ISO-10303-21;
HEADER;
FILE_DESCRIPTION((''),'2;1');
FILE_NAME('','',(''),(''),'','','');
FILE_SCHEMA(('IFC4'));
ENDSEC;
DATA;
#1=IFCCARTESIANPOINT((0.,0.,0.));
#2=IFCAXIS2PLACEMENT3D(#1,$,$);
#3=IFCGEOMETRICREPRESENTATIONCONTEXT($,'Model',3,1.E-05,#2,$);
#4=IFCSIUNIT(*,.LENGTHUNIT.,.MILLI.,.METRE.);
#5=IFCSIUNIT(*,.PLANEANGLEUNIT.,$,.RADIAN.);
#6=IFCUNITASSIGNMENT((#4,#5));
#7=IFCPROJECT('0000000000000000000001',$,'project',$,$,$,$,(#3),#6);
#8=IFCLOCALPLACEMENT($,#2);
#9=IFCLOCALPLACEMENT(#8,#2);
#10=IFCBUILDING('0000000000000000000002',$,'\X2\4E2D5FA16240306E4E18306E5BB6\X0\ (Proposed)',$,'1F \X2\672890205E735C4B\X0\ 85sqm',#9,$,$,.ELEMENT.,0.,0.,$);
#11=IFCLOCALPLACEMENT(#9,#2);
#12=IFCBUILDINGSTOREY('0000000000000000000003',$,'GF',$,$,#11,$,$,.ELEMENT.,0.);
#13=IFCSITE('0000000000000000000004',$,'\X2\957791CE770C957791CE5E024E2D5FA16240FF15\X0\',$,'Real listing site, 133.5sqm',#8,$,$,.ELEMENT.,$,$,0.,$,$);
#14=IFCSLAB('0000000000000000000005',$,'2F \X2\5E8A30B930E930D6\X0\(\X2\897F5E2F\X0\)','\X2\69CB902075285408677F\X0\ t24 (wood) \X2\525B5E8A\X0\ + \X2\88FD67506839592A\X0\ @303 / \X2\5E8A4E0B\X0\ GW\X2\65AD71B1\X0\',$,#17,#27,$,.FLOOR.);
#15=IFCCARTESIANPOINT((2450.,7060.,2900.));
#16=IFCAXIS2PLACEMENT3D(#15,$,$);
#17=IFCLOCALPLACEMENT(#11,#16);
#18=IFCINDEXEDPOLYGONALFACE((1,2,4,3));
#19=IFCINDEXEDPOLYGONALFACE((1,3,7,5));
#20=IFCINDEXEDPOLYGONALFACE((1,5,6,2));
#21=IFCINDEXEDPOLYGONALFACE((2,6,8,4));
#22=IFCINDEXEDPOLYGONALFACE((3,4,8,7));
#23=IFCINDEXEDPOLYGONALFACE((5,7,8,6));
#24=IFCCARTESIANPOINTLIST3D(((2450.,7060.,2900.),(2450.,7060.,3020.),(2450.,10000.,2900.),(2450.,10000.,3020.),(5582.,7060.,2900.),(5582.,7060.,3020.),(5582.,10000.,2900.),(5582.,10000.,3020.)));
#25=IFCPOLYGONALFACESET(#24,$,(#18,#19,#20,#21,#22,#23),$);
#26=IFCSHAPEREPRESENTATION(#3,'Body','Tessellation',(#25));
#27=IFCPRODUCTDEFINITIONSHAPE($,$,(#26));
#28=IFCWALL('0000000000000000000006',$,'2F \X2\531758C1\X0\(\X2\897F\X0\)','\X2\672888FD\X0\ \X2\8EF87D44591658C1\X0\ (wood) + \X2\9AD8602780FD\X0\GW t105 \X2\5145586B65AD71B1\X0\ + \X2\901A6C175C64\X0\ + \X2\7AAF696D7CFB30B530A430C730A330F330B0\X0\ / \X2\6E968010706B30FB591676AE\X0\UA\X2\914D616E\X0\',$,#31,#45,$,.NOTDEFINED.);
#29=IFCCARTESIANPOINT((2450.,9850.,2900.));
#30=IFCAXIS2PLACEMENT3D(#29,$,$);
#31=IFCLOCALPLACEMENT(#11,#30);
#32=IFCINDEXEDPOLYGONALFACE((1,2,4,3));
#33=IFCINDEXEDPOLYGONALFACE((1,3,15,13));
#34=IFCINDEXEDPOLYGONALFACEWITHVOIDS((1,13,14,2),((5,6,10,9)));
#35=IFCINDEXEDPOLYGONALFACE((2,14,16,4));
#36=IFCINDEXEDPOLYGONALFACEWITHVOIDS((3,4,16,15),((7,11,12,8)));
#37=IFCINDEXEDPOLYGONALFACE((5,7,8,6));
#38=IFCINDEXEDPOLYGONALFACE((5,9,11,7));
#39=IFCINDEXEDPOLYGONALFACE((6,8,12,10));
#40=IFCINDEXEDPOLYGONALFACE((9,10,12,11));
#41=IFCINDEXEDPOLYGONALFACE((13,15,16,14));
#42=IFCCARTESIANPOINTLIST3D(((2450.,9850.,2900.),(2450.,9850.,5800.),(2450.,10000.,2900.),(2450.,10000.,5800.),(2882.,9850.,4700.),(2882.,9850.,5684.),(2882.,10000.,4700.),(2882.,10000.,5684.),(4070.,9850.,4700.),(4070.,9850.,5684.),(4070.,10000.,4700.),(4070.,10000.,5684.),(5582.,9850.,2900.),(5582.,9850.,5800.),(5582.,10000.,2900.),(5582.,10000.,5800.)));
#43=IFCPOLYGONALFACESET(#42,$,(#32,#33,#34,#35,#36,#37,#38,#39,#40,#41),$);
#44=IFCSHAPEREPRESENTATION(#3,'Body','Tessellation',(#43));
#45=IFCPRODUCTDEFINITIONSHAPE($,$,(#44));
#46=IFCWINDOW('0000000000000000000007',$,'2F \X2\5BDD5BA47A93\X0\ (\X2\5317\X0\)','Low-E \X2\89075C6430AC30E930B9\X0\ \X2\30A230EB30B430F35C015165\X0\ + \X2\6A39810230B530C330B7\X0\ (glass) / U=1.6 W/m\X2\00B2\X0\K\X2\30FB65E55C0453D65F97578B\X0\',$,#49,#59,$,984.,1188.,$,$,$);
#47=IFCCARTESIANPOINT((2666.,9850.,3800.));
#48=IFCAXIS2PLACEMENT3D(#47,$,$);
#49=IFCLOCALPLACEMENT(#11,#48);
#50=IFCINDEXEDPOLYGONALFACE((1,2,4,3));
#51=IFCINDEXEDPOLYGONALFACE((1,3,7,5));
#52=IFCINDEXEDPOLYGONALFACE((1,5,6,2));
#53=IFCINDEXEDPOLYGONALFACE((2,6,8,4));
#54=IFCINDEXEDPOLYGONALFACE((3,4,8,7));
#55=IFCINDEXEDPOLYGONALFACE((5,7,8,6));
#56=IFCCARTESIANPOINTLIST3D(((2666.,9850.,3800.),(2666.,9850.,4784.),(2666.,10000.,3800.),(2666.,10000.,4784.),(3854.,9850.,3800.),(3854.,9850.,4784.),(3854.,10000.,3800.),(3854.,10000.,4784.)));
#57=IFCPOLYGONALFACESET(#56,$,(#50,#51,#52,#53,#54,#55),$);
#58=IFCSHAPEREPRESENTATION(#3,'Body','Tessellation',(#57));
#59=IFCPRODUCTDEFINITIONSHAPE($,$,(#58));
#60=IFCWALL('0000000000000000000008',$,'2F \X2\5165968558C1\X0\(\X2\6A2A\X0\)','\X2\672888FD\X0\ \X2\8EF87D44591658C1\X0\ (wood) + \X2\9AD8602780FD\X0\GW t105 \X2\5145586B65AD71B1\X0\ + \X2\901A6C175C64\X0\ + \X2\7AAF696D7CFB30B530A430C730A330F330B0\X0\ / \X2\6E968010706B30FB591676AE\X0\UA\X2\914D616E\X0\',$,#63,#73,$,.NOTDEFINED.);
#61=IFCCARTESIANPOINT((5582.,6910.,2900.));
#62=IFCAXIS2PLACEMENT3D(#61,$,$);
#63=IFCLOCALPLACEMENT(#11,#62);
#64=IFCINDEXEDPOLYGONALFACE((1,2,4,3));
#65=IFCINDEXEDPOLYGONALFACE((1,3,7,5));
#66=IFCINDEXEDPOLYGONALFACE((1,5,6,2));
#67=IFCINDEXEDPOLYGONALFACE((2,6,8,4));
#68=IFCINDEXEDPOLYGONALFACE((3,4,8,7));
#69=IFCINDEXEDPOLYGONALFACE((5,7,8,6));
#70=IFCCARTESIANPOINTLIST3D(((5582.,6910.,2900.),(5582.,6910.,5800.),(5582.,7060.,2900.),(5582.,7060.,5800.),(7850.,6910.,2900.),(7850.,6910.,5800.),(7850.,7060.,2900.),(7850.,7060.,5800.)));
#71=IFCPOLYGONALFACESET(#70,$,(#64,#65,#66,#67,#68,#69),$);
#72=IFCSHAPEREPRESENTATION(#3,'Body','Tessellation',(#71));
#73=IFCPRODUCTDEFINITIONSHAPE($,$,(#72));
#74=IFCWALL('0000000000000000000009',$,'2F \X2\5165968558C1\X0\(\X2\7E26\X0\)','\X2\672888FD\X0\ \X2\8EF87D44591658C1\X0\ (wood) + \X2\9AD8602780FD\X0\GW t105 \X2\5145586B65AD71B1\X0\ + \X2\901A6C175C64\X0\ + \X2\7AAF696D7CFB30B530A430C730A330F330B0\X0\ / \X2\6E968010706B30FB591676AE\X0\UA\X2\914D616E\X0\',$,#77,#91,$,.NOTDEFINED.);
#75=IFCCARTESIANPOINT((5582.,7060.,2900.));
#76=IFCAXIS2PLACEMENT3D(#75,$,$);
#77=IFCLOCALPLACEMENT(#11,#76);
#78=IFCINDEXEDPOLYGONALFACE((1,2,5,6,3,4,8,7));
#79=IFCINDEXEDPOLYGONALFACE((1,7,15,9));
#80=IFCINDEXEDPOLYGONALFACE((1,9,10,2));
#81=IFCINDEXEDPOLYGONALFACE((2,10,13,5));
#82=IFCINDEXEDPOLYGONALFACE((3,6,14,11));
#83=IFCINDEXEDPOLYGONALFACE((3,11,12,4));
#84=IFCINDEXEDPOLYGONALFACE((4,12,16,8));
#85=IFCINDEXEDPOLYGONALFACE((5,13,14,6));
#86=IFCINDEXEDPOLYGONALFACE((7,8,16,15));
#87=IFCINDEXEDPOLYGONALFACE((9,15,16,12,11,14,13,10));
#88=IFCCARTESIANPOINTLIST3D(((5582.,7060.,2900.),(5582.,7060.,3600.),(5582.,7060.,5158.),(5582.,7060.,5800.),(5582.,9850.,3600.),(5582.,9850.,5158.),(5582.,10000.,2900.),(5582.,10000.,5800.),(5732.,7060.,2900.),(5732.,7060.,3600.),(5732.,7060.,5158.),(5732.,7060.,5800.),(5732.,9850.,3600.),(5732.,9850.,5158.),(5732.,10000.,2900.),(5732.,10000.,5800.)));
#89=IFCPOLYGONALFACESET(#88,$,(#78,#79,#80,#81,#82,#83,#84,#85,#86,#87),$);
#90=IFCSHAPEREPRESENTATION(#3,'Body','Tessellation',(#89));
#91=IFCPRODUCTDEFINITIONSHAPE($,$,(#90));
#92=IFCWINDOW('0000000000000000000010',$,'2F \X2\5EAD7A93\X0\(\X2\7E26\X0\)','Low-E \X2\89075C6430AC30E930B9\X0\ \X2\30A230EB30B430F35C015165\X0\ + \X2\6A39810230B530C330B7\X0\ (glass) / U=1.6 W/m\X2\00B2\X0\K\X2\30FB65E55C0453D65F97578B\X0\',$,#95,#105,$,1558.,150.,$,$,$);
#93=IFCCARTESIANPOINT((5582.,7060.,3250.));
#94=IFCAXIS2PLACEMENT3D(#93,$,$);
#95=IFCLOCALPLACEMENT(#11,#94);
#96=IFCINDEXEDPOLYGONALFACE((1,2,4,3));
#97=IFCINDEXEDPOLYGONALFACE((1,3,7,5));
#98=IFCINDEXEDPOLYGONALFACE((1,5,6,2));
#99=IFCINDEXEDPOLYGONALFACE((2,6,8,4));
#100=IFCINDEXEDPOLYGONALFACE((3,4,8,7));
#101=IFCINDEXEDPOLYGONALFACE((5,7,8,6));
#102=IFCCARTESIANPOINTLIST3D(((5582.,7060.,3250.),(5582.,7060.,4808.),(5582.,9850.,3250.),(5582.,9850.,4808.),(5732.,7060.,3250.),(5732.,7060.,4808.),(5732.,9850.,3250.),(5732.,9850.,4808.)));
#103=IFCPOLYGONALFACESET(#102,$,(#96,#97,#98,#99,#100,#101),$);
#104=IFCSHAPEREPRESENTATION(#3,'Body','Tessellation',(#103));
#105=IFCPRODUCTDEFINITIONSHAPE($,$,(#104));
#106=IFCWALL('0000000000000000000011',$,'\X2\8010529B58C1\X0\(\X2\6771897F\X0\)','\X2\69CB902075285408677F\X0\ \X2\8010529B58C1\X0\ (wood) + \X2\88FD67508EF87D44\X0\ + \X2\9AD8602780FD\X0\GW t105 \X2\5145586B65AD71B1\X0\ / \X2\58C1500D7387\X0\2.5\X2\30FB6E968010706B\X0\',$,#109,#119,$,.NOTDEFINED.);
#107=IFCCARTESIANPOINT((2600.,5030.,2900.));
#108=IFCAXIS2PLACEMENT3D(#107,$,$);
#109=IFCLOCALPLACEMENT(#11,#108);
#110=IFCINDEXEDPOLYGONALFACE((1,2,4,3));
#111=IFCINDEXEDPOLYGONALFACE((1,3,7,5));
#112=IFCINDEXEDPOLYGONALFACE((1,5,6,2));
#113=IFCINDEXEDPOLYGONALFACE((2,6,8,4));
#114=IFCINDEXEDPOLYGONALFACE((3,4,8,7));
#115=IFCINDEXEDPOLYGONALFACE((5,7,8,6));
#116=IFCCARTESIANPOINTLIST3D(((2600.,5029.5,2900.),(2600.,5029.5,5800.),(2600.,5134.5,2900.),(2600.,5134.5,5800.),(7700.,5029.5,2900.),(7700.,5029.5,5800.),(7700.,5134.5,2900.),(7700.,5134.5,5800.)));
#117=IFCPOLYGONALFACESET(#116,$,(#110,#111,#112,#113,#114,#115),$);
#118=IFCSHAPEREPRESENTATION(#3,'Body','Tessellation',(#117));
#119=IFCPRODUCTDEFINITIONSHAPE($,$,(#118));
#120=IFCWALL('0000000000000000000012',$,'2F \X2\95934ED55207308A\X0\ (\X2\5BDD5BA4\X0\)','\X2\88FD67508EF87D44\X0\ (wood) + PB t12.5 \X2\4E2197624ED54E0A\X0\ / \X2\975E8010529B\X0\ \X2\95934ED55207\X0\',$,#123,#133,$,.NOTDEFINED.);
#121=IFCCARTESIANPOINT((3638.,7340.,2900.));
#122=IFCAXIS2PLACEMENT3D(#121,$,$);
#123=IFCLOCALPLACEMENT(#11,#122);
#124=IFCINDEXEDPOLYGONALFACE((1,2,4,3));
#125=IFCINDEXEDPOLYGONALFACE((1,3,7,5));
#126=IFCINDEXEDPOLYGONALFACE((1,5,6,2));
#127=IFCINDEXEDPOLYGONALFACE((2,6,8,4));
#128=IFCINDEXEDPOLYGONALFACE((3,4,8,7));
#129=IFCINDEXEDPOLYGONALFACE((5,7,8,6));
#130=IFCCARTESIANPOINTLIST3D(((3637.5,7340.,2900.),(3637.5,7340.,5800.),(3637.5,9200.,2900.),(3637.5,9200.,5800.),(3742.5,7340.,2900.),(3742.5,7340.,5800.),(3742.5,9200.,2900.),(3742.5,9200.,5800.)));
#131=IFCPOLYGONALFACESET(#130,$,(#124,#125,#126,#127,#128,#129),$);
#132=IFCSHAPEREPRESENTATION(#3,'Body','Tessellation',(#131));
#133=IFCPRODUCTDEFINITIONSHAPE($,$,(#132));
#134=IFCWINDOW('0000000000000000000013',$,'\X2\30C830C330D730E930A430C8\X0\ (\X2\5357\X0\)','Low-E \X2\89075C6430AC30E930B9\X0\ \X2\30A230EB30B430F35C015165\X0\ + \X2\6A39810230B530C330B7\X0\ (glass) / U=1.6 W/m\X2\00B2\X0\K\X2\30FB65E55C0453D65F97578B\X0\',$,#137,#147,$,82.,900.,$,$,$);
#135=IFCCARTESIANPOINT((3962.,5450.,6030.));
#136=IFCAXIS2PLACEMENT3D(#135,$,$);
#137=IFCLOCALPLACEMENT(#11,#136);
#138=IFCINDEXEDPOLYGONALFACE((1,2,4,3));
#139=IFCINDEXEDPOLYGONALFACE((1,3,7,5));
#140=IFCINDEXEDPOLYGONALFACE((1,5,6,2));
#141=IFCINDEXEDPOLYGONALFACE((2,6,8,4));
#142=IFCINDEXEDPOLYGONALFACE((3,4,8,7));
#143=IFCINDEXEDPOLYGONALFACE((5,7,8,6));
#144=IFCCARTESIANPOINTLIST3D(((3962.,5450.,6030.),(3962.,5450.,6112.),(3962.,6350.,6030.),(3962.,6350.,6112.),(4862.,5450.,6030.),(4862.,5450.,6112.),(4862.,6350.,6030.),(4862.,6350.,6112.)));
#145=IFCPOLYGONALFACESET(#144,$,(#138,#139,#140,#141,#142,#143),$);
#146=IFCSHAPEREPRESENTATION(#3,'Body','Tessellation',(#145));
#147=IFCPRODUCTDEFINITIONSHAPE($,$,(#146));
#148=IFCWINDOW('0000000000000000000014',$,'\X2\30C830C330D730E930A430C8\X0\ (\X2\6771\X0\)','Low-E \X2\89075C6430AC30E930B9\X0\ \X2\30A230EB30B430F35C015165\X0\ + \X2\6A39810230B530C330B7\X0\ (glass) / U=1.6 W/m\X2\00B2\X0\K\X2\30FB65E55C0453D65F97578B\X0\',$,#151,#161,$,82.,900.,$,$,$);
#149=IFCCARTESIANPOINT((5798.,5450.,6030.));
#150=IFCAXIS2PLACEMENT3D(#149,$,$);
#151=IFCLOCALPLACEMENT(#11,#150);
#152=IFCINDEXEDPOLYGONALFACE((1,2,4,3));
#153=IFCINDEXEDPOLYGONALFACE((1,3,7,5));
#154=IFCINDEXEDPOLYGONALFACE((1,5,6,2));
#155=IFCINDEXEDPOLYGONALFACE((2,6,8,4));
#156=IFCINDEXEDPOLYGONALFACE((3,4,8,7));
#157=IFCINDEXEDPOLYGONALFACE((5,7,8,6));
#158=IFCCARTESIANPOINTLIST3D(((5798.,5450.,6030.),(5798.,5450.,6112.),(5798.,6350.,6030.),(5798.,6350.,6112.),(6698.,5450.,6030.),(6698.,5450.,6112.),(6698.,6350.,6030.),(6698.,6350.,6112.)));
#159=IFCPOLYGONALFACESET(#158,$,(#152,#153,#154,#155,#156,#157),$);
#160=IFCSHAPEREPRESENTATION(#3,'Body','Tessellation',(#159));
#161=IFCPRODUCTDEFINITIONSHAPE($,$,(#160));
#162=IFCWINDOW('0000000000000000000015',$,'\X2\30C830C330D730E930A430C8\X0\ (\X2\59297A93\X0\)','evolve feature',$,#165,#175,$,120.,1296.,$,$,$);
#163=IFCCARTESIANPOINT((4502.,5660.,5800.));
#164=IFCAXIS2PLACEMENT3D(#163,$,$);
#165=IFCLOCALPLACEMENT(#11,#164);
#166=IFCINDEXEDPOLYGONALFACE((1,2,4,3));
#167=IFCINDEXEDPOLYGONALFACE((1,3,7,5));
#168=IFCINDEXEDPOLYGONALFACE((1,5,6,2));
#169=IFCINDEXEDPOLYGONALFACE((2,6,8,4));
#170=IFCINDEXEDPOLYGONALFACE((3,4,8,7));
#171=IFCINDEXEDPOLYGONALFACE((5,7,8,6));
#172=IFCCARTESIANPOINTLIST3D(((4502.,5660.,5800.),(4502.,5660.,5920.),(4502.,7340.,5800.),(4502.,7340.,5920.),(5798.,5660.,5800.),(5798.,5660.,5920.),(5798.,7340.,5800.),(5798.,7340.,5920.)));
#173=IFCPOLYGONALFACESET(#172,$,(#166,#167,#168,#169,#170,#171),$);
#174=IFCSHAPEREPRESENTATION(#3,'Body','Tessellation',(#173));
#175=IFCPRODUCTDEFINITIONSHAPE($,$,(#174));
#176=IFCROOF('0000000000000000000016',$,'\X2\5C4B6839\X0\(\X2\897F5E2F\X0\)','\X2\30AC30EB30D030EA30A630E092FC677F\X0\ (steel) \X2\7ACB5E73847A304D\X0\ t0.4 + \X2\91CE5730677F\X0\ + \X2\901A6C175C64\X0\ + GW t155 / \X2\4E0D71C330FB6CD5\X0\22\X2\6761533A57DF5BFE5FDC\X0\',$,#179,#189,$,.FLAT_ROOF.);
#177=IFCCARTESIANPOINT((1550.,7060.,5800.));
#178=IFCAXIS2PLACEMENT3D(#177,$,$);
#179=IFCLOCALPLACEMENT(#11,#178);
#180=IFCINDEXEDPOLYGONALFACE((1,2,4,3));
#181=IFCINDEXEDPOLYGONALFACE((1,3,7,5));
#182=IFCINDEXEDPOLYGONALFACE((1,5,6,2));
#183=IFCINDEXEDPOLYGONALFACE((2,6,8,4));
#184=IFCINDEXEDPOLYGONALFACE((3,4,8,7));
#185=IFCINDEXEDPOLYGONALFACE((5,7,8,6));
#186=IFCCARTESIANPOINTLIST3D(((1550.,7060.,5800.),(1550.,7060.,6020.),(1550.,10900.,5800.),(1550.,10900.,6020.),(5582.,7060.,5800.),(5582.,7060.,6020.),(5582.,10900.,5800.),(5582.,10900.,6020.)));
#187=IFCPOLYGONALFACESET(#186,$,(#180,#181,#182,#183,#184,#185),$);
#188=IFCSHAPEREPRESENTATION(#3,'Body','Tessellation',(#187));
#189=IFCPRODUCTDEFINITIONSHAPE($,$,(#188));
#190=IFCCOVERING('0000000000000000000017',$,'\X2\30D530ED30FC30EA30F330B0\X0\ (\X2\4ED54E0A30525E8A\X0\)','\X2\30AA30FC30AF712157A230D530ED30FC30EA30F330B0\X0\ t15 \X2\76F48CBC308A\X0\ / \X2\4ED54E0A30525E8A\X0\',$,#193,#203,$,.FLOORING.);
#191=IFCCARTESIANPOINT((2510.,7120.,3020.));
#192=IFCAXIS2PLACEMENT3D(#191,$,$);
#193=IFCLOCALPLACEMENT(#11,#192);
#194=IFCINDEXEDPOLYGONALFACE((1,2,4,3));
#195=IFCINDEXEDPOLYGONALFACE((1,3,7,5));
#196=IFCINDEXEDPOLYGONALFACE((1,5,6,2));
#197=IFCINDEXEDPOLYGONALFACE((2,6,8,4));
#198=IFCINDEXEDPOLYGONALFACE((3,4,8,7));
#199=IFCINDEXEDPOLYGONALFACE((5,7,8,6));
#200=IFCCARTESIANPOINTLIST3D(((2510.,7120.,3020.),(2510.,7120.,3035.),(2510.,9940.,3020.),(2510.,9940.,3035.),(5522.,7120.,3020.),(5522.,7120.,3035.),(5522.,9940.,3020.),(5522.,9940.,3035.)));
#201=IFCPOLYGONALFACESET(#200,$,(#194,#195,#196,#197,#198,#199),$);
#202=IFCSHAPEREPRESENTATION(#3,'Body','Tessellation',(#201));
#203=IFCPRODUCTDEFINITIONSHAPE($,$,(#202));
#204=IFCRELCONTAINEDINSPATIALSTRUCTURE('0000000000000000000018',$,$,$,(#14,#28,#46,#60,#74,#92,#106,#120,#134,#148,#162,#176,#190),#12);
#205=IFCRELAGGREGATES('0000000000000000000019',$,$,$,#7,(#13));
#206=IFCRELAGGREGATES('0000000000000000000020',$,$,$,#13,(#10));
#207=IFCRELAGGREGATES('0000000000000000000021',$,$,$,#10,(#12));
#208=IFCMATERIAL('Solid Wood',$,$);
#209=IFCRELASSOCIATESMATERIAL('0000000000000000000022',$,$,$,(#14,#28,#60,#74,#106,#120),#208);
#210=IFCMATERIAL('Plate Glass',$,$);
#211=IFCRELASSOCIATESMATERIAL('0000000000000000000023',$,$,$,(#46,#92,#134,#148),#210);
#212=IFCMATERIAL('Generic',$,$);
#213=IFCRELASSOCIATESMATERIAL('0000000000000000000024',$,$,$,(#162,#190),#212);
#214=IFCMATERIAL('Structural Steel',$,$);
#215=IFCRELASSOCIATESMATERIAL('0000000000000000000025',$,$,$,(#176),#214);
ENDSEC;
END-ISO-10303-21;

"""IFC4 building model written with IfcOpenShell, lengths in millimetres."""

from ifc_helpers import new_model, si_unit, frame, frame_2d, origin, place, context, project, spatial, rectangle, extrude, material, element, fill, save


model = new_model("IFC4")

# Units and contexts
model_context = context("Model", 3, precision=1e-05, world=origin())
ifc_project = project(units=[si_unit("LENGTHUNIT", "METRE", prefix="MILLI"), si_unit("PLANEANGLEUNIT", "RADIAN")], contexts=[model_context])

# Site, building, storey
site_placement = place(None, origin())
site = spatial("IfcSite", under=ifc_project, at=site_placement, Name="長野県長野市中御所５", ObjectType="Real listing site, 133.5sqm", CompositionType="ELEMENT", RefElevation=0.0)
building_placement = place(site_placement, origin())
building = spatial("IfcBuilding", under=site, at=building_placement, Name="中御所の丘の家 (Proposed)", ObjectType="1F 木造平屋 85sqm", CompositionType="ELEMENT", ElevationOfRefHeight=0.0, ElevationOfTerrain=0.0)
storey_placement = place(building_placement, origin())
storey = spatial("IfcBuildingStorey", under=building, at=storey_placement, Name="GF", CompositionType="ELEMENT", Elevation=0.0)

# Slab
ifc_material_1 = material(Name="Solid Wood")
slab_placement = place(storey_placement, frame((2450.0, 7060.0, 2900.0)))
element("IfcSlab", 1, at=slab_placement, inside=storey, material=ifc_material_1, Name="2F 床スラブ(西帯)", Description="構造用合板 t24 (wood) 剛床 + 製材根太 @303 / 床下 GW断熱", PredefinedType="FLOOR", context=model_context, shape_type="SweptSolid", body=[
    extrude(rectangle(XDim=3132.0, YDim=2940.0, at=frame_2d((1566.0, 1470.0))), frame((2450.0, 7060.0, 2900.0)), (0.0, 0.0, 1.0), 120.0),
])

# Wall, opening, window
wall_1_placement = place(storey_placement, frame((2450.0, 9850.0, 2900.0)))
wall_1 = element("IfcWall", 2, at=wall_1_placement, inside=storey, material=ifc_material_1, Name="2F 北壁(西)", Description="木製 軸組外壁 (wood) + 高性能GW t105 充填断熱 + 通気層 + 窯業系サイディング / 準耐火・外皮UA配慮", PredefinedType="NOTDEFINED", context=model_context, shape_type="SweptSolid", body=[
    extrude(rectangle(XDim=3132.0, YDim=150.0, at=frame_2d((1566.0, 75.0))), frame((2450.0, 9850.0, 2900.0)), (0.0, 0.0, 1.0), 2900.0),
])
opening_1_placement = place(storey_placement, frame((2666.0, 9850.0, 3800.0)))
opening_1 = element("IfcOpeningElement", 3, at=opening_1_placement, cuts=wall_1, PredefinedType="NOTDEFINED", context=model_context, shape_type="SweptSolid", body=[
    extrude(rectangle(XDim=1188.0, YDim=150.0, at=frame_2d((594.0, 75.0))), frame((2666.0, 9850.0, 3800.0)), (0.0, 0.0, 1.0), 984.0),
])
ifc_material_2 = material(Name="Plate Glass")
window_1_placement = place(storey_placement, frame((2666.0, 9850.0, 3800.0)))
window_1 = element("IfcWindow", 4, at=window_1_placement, inside=storey, material=ifc_material_2, Name="2F 寝室窓 (北)", Description="Low-E 複層ガラス アルゴン封入 + 樹脂サッシ (glass) / U=1.6 W/m²K・日射取得型", OverallHeight=984.0, OverallWidth=1188.0, context=model_context, shape_type="SweptSolid", body=[
    extrude(rectangle(XDim=1188.0, YDim=150.0, at=frame_2d((594.0, 75.0))), frame((2666.0, 9850.0, 3800.0)), (0.0, 0.0, 1.0), 984.0),
])
fill(opening_1, window_1)

# Wall
wall_2_placement = place(storey_placement, frame((5582.0, 6910.0, 2900.0)))
element("IfcWall", 5, at=wall_2_placement, inside=storey, material=ifc_material_1, Name="2F 入隅壁(横)", Description="木製 軸組外壁 (wood) + 高性能GW t105 充填断熱 + 通気層 + 窯業系サイディング / 準耐火・外皮UA配慮", PredefinedType="NOTDEFINED", context=model_context, shape_type="SweptSolid", body=[
    extrude(rectangle(XDim=2268.0, YDim=150.0, at=frame_2d((1134.0, 75.0))), frame((5582.0, 6910.0, 2900.0)), (0.0, 0.0, 1.0), 2900.0),
])

# Wall, opening, window
wall_3_placement = place(storey_placement, frame((5582.0, 7060.0, 2900.0)))
wall_3 = element("IfcWall", 6, at=wall_3_placement, inside=storey, material=ifc_material_1, Name="2F 入隅壁(縦)", Description="木製 軸組外壁 (wood) + 高性能GW t105 充填断熱 + 通気層 + 窯業系サイディング / 準耐火・外皮UA配慮", PredefinedType="NOTDEFINED", context=model_context, shape_type="SweptSolid", body=[
    extrude(rectangle(XDim=150.0, YDim=2940.0, at=frame_2d((75.0, 1470.0))), frame((5582.0, 7060.0, 2900.0)), (0.0, 0.0, 1.0), 2900.0),
])
opening_2_placement = place(storey_placement, frame((5582.0, 7060.0, 3250.0)))
opening_2 = element("IfcOpeningElement", 7, at=opening_2_placement, cuts=wall_3, PredefinedType="NOTDEFINED", context=model_context, shape_type="SweptSolid", body=[
    extrude(rectangle(XDim=150.0, YDim=2790.0, at=frame_2d((75.0, 1395.0))), frame((5582.0, 7060.0, 3250.0)), (0.0, 0.0, 1.0), 1558.0),
])
window_2_placement = place(storey_placement, frame((5582.0, 7060.0, 3250.0)))
window_2 = element("IfcWindow", 8, at=window_2_placement, inside=storey, material=ifc_material_2, Name="2F 庭窓(縦)", Description="Low-E 複層ガラス アルゴン封入 + 樹脂サッシ (glass) / U=1.6 W/m²K・日射取得型", OverallHeight=1558.0, OverallWidth=150.0, context=model_context, shape_type="SweptSolid", body=[
    extrude(rectangle(XDim=150.0, YDim=2790.0, at=frame_2d((75.0, 1395.0))), frame((5582.0, 7060.0, 3250.0)), (0.0, 0.0, 1.0), 1558.0),
])
fill(opening_2, window_2)

# Walls
wall_4_placement = place(storey_placement, frame((2600.0, 5030.0, 2900.0)))
element("IfcWall", 9, at=wall_4_placement, inside=storey, material=ifc_material_1, Name="耐力壁(東西)", Description="構造用合板 耐力壁 (wood) + 製材軸組 + 高性能GW t105 充填断熱 / 壁倍率2.5・準耐火", PredefinedType="NOTDEFINED", context=model_context, shape_type="SweptSolid", body=[
    extrude(rectangle(XDim=5100.0, YDim=105.0, at=frame_2d((2550.0, 52.0))), frame((2600.0, 5030.0, 2900.0)), (0.0, 0.0, 1.0), 2900.0),
])
wall_5_placement = place(storey_placement, frame((3638.0, 7340.0, 2900.0)))
element("IfcWall", 10, at=wall_5_placement, inside=storey, material=ifc_material_1, Name="2F 間仕切り (寝室)", Description="製材軸組 (wood) + PB t12.5 両面仕上 / 非耐力 間仕切", PredefinedType="NOTDEFINED", context=model_context, shape_type="SweptSolid", body=[
    extrude(rectangle(XDim=105.0, YDim=1860.0, at=frame_2d((52.0, 930.0))), frame((3638.0, 7340.0, 2900.0)), (0.0, 0.0, 1.0), 2900.0),
])

# Windows
window_3_placement = place(storey_placement, frame((3962.0, 5450.0, 6030.0)))
element("IfcWindow", 11, at=window_3_placement, inside=storey, material=ifc_material_2, Name="トップライト (南)", Description="Low-E 複層ガラス アルゴン封入 + 樹脂サッシ (glass) / U=1.6 W/m²K・日射取得型", OverallHeight=82.0, OverallWidth=900.0, context=model_context, shape_type="SweptSolid", body=[
    extrude(rectangle(XDim=900.0, YDim=900.0, at=frame_2d((450.0, 450.0))), frame((3962.0, 5450.0, 6030.0)), (0.0, 0.0, 1.0), 82.0),
])
window_4_placement = place(storey_placement, frame((5798.0, 5450.0, 6030.0)))
element("IfcWindow", 12, at=window_4_placement, inside=storey, material=ifc_material_2, Name="トップライト (東)", Description="Low-E 複層ガラス アルゴン封入 + 樹脂サッシ (glass) / U=1.6 W/m²K・日射取得型", OverallHeight=82.0, OverallWidth=900.0, context=model_context, shape_type="SweptSolid", body=[
    extrude(rectangle(XDim=900.0, YDim=900.0, at=frame_2d((450.0, 450.0))), frame((5798.0, 5450.0, 6030.0)), (0.0, 0.0, 1.0), 82.0),
])
ifc_material_3 = material(Name="Generic")
window_5_placement = place(storey_placement, frame((4502.0, 5660.0, 5800.0)))
element("IfcWindow", 13, at=window_5_placement, inside=storey, material=ifc_material_3, Name="トップライト (天窓)", Description="evolve feature", OverallHeight=120.0, OverallWidth=1296.0, context=model_context, shape_type="SweptSolid", body=[
    extrude(rectangle(XDim=1296.0, YDim=1680.0, at=frame_2d((648.0, 840.0))), frame((4502.0, 5660.0, 5800.0)), (0.0, 0.0, 1.0), 120.0),
])

# Roof
ifc_material_4 = material(Name="Structural Steel")
for number, where, name in (
    (14, (1550.0, 7060.0, 5800.0), "屋根(西帯)"),
):
    element("IfcRoof", number, at=place(storey_placement, frame(where)), inside=storey, material=ifc_material_4, Name=name, Description="ガルバリウム鋼板 (steel) 立平葺き t0.4 + 野地板 + 通気層 + GW t155 / 不燃・法22条区域対応", PredefinedType="FLAT_ROOF", context=model_context, shape_type="SweptSolid", body=[
        extrude(rectangle(XDim=4032.0, YDim=3840.0, at=frame_2d((2016.0, 1920.0))), frame((1550.0, 7060.0, 5800.0)), (0.0, 0.0, 1.0), 220.0),
    ])

# Covering
covering_placement = place(storey_placement, frame((2510.0, 7120.0, 3020.0)))
element("IfcCovering", 15, at=covering_placement, inside=storey, material=ifc_material_3, Name="フローリング (仕上げ床)", Description="オーク無垢フローリング t15 直貼り / 仕上げ床", PredefinedType="FLOORING", context=model_context, shape_type="SweptSolid", body=[
    extrude(rectangle(XDim=3012.0, YDim=2820.0, at=frame_2d((1506.0, 1410.0))), frame((2510.0, 7120.0, 3020.0)), (0.0, 0.0, 1.0), 15.0),
])

save(model, "model.ifc")
